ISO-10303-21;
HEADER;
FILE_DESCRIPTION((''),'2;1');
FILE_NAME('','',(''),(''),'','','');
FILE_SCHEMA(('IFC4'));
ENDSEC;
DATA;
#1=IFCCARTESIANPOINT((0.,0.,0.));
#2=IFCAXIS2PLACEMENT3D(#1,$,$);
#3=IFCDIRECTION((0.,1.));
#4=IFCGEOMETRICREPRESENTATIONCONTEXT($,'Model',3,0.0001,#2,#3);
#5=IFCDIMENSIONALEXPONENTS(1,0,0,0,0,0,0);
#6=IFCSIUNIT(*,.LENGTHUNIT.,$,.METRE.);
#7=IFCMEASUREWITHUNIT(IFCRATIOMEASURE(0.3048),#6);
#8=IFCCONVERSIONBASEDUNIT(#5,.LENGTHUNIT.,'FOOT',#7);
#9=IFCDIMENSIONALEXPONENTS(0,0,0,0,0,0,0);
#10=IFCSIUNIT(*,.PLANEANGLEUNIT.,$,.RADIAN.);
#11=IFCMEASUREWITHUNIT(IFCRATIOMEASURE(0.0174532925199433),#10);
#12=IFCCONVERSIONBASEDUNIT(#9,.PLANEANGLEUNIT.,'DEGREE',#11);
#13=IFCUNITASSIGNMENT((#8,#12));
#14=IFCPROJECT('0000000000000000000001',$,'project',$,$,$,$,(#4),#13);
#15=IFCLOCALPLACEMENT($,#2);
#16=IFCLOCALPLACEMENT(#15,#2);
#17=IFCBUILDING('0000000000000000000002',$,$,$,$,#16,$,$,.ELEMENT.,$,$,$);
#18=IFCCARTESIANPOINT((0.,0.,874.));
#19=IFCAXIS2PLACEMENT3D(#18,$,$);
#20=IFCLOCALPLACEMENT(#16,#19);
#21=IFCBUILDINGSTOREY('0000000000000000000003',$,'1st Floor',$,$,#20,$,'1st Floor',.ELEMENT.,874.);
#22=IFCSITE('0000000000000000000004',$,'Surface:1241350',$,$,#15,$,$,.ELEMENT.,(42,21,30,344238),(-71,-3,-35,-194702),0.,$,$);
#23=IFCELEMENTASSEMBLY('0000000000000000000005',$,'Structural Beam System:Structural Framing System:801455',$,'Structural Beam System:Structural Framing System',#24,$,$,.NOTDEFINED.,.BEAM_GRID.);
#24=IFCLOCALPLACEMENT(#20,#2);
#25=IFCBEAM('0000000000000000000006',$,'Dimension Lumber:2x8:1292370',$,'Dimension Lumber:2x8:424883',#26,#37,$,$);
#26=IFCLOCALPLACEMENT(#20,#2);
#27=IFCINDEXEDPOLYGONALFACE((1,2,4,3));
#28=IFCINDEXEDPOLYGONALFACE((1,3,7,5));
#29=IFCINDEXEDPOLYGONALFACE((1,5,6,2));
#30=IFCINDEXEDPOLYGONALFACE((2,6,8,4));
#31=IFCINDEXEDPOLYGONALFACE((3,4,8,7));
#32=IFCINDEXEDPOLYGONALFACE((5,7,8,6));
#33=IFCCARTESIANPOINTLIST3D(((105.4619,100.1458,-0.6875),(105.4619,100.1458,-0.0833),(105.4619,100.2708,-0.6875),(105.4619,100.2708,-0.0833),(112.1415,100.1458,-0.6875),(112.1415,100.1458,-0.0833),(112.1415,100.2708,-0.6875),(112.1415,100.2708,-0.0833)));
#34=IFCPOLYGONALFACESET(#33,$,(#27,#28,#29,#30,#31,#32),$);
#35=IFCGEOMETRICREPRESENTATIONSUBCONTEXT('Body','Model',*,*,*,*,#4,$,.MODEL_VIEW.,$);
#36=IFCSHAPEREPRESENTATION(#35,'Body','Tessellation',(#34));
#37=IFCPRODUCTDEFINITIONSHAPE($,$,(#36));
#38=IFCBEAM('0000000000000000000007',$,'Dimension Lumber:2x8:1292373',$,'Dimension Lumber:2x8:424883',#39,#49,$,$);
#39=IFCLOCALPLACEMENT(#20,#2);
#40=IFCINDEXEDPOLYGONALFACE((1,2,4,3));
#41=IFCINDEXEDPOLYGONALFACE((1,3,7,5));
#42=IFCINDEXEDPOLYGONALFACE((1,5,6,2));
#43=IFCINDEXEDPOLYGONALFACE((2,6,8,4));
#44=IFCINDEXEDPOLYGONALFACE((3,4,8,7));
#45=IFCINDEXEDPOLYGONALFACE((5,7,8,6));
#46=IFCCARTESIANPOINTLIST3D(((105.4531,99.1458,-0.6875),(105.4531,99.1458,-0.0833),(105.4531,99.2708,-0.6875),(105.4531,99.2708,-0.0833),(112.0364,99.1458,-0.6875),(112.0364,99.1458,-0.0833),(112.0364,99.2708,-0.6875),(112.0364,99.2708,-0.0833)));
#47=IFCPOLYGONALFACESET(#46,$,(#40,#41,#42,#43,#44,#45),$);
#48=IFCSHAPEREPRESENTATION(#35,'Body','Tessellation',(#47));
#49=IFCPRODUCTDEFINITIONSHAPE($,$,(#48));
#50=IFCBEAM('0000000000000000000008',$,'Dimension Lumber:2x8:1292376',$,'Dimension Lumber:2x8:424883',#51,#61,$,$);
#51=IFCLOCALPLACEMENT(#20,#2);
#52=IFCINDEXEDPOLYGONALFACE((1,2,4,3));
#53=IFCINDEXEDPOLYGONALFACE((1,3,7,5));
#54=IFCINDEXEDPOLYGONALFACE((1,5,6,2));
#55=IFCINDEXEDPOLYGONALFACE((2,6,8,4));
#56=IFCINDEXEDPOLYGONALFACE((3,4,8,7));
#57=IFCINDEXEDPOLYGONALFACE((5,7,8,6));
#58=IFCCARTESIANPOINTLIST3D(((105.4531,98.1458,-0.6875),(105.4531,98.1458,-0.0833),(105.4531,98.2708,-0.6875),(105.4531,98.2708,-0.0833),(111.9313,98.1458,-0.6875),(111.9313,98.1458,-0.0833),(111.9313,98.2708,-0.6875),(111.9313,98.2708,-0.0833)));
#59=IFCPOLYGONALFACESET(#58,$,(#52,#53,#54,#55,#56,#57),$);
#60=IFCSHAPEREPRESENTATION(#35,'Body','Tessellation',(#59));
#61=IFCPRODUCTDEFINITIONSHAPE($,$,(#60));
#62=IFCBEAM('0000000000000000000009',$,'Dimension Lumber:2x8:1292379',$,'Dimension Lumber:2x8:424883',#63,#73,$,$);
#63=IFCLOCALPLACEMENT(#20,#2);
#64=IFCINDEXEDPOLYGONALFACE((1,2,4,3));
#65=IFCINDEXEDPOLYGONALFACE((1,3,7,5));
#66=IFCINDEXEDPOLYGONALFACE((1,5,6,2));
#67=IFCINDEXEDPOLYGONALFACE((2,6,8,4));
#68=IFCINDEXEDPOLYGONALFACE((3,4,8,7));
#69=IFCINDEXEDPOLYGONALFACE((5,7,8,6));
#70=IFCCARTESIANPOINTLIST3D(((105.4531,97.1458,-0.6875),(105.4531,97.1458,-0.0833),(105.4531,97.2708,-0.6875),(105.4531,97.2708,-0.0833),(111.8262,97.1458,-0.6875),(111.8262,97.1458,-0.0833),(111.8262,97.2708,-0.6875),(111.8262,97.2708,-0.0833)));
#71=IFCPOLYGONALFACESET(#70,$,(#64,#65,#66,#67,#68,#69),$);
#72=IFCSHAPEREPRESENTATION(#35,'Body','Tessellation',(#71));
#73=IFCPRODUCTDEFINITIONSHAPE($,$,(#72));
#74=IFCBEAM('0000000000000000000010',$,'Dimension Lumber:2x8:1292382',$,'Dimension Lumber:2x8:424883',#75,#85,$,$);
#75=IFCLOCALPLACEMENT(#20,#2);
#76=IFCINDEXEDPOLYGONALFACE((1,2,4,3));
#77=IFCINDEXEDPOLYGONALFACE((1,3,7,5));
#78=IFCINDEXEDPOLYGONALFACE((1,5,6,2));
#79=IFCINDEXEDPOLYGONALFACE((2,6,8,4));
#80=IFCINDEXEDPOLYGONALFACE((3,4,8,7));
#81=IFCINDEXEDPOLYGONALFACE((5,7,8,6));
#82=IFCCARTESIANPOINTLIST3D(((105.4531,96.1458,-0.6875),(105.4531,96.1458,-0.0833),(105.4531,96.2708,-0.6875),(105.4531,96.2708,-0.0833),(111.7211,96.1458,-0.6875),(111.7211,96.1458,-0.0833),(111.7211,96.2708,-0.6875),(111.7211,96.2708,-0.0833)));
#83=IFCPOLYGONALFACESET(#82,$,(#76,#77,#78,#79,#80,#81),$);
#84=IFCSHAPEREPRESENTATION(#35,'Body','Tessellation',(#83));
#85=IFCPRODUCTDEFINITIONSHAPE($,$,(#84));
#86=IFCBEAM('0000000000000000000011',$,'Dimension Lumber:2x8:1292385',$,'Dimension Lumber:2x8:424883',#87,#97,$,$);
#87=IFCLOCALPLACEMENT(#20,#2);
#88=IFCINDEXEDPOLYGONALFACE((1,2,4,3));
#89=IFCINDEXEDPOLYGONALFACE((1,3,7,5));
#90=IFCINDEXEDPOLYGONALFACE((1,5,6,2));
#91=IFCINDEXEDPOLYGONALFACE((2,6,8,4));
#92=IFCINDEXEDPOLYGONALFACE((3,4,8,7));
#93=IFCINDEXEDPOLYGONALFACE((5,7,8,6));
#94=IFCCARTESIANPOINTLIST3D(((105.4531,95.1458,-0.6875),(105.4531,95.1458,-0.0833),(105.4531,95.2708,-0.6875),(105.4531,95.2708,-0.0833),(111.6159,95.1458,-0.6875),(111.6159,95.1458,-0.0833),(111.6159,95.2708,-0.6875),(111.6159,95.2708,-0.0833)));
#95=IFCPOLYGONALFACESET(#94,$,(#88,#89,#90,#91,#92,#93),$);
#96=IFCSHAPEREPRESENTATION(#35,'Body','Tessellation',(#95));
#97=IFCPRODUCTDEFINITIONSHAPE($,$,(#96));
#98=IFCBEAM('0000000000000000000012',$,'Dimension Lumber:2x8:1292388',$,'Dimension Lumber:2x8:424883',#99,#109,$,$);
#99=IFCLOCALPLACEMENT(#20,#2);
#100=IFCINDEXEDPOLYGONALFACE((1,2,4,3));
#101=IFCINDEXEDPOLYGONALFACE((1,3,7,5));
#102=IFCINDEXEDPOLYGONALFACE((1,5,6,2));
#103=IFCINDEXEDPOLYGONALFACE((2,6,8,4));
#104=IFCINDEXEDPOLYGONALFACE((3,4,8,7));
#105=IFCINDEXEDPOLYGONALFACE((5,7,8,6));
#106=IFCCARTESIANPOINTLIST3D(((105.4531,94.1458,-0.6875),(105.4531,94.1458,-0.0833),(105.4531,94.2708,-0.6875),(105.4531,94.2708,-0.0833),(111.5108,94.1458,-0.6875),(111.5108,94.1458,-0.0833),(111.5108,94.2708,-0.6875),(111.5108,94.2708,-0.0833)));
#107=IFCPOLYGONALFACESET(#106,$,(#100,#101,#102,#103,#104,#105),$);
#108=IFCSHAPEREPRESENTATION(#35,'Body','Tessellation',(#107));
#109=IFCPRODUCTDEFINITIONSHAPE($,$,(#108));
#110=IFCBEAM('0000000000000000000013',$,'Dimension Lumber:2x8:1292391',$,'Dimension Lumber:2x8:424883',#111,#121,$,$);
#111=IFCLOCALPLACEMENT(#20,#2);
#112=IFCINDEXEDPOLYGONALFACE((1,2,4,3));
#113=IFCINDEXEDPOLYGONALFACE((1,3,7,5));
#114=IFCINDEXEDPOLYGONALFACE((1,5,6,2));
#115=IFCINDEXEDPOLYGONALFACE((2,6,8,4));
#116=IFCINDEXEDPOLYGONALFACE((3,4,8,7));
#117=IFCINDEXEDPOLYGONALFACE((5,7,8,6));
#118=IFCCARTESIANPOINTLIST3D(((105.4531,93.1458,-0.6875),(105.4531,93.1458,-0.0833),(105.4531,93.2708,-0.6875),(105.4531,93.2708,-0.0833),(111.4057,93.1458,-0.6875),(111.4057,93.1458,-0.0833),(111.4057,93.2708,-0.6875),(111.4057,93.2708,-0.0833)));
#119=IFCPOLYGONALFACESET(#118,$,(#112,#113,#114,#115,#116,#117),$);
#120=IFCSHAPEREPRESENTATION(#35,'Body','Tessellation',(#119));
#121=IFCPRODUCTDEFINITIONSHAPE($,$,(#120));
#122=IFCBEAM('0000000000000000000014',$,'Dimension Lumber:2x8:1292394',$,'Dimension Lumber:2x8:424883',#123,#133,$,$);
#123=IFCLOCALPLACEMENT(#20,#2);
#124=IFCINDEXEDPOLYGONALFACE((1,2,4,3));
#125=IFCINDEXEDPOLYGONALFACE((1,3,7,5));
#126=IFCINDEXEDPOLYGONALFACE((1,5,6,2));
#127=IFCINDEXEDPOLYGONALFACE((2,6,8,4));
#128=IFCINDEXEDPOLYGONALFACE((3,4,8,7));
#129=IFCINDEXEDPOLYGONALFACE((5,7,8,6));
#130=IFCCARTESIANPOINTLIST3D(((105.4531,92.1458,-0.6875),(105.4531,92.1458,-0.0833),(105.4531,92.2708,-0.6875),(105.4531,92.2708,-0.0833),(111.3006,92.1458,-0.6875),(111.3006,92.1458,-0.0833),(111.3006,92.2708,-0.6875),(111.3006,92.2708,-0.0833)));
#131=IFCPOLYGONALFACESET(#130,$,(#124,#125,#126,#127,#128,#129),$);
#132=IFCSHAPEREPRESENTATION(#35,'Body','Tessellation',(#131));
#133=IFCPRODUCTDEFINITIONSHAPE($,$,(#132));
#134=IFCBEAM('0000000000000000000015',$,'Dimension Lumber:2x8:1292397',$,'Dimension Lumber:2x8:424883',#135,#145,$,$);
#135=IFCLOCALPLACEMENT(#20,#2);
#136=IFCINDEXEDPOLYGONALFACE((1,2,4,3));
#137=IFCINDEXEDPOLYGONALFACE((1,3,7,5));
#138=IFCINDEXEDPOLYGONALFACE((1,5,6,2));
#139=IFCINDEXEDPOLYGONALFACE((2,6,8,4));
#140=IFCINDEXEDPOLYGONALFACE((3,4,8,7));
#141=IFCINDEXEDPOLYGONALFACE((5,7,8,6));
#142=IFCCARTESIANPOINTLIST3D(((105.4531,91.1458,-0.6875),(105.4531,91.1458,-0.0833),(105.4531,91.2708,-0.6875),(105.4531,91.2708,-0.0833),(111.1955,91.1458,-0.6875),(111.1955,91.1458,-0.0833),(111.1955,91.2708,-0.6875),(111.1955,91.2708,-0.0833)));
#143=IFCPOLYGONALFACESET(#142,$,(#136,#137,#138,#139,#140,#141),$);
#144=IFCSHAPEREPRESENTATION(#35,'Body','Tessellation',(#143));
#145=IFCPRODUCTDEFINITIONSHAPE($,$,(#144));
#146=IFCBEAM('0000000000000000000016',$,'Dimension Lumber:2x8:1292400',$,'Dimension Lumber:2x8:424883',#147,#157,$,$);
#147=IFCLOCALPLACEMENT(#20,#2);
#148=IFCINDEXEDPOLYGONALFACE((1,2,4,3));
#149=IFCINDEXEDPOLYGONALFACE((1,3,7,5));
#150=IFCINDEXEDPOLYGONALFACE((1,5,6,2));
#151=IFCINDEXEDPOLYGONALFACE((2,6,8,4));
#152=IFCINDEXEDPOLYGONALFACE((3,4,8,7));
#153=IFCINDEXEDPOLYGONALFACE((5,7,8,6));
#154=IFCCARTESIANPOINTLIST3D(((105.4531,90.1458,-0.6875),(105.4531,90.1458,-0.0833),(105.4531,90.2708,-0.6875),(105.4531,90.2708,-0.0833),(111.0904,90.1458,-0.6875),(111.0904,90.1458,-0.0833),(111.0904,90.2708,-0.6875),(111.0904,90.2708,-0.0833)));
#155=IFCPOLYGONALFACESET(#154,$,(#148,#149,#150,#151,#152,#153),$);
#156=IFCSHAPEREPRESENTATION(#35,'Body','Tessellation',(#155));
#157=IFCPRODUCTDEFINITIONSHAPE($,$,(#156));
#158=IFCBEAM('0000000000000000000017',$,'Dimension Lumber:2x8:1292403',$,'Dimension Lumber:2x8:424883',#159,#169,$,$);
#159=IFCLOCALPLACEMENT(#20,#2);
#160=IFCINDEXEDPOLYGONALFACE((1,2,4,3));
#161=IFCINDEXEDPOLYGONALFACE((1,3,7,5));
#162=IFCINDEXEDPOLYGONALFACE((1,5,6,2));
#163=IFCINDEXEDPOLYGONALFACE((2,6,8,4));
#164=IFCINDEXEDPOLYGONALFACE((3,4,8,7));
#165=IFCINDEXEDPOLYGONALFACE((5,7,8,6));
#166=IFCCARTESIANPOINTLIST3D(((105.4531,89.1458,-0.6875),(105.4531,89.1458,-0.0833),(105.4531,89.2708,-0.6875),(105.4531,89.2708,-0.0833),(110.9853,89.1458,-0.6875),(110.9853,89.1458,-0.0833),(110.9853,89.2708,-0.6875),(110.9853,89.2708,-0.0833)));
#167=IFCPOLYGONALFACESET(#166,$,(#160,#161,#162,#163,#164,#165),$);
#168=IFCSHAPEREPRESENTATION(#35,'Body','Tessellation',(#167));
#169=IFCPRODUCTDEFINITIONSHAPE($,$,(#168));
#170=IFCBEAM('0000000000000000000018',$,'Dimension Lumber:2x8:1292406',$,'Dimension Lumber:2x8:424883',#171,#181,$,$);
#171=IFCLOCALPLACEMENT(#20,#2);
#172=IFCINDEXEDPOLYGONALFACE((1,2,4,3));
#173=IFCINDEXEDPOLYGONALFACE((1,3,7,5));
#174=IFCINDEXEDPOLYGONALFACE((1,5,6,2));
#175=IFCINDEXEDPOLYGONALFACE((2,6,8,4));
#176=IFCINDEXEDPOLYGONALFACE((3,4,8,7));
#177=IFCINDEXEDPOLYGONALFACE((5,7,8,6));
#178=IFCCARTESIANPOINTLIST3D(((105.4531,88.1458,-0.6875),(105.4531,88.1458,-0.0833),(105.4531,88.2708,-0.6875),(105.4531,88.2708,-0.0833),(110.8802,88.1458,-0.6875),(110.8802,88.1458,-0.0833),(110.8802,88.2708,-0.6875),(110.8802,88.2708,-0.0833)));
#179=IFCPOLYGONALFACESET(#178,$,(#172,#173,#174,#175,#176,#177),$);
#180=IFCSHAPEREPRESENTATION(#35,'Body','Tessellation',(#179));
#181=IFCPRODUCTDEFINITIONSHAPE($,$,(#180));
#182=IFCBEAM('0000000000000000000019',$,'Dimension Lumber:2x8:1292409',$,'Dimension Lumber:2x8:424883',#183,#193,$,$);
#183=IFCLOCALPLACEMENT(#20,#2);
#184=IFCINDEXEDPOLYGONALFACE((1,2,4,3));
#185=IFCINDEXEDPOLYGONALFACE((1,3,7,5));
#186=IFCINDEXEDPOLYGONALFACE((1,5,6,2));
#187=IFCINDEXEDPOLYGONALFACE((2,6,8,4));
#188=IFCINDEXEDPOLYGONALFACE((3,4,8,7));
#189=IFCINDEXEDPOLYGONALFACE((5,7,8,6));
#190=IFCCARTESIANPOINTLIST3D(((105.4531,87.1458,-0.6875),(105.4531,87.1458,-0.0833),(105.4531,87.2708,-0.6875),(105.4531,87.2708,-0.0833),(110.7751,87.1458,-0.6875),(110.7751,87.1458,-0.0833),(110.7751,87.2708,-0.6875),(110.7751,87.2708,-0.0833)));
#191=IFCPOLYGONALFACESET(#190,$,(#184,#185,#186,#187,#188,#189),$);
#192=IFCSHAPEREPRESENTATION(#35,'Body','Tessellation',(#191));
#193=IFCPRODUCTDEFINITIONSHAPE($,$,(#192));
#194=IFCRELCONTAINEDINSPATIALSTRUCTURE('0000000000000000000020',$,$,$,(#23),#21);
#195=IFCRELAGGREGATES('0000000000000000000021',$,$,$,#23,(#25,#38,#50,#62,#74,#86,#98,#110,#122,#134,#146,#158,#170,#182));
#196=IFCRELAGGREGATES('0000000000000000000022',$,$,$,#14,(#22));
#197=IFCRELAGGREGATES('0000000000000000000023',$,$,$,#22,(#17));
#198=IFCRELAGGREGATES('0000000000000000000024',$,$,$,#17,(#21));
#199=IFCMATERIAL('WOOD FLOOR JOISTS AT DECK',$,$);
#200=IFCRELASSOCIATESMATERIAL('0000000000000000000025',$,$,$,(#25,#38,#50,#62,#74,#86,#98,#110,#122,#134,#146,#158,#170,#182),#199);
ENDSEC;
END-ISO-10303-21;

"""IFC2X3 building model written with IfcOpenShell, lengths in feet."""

from ifc_helpers import new_model, entity, si_unit, converted_unit, direction, frame, origin, origin_2d_with_axis, place, context, subcontext, project, spatial, rectangle, extrude, material, element, aggregate, save


model = new_model("IFC2X3")

# Units and contexts
model_context = context("Model", 3, precision=0.0001, world=origin(), true_north=direction((0.0, 1.0)))
body_context = subcontext(model_context, "Body", "Model", "MODEL_VIEW")
ifc_project = project(units=[converted_unit("LENGTHUNIT", "FOOT", entity("IfcRatioMeasure", 0.3048), si_unit("LENGTHUNIT", "METRE"), dimensions=[1, 0, 0, 0, 0, 0, 0]), converted_unit("PLANEANGLEUNIT", "DEGREE", entity("IfcRatioMeasure", 0.0174532925199433), si_unit("PLANEANGLEUNIT", "RADIAN"), dimensions=[0, 0, 0, 0, 0, 0, 0])], contexts=[model_context])

# Site, building, storey
site_placement = place(None, origin())
site = spatial("IfcSite", under=ifc_project, at=site_placement, Name="Surface:1241350", CompositionType="ELEMENT", RefLatitude=(42, 21, 30, 344238), RefLongitude=(-71, -3, -35, -194702), RefElevation=0.0)
building_placement = place(site_placement, origin())
building = spatial("IfcBuilding", under=site, at=building_placement, CompositionType="ELEMENT")
storey_placement = place(building_placement, frame((0.0, 0.0, 874.0)))
storey = spatial("IfcBuildingStorey", under=building, at=storey_placement, Name="1st Floor", LongName="1st Floor", CompositionType="ELEMENT", Elevation=874.0)

# Element assembly, beams
assembly_placement = place(storey_placement, origin())
assembly = element("IfcElementAssembly", 1, at=assembly_placement, inside=storey, Name="Structural Beam System:Structural Framing System:801455", ObjectType="Structural Beam System:Structural Framing System", AssemblyPlace="NOTDEFINED", PredefinedType="BEAM_GRID")
ifc_material_1 = material(Name="WOOD FLOOR JOISTS AT DECK")
beam_1_placement = place(assembly_placement, frame((105.4619, 100.2083, 0.0)))
beam_1 = element("IfcBeam", 2, at=beam_1_placement, material=ifc_material_1, Name="Dimension Lumber:2x8:1292370", ObjectType="Dimension Lumber:2x8:424883", context=body_context, shape_type="SweptSolid", body=[
    extrude(rectangle(XDim=0.6042, YDim=0.125, at=origin_2d_with_axis()), frame((0.0, 0.0, -0.3854), z_axis=(1.0, 0.0, 0.0), x_axis=(0.0, 0.0, -1.0)), (0.0, 0.0, 1.0), 6.6796),
])
beam_2_placement = place(assembly_placement, frame((105.3906, 99.2083, 0.0)))
beam_2 = element("IfcBeam", 3, at=beam_2_placement, material=ifc_material_1, Name="Dimension Lumber:2x8:1292373", ObjectType="Dimension Lumber:2x8:424883", context=body_context, shape_type="SweptSolid", body=[
    extrude(rectangle(XDim=0.6042, YDim=0.125, at=origin_2d_with_axis()), frame((0.0625, 0.0, -0.3854), z_axis=(1.0, 0.0, 0.0), x_axis=(0.0, 0.0, -1.0)), (0.0, 0.0, 1.0), 6.5832),
])
beam_3_placement = place(assembly_placement, frame((105.3906, 98.2083, 0.0)))
beam_3 = element("IfcBeam", 4, at=beam_3_placement, material=ifc_material_1, Name="Dimension Lumber:2x8:1292376", ObjectType="Dimension Lumber:2x8:424883", context=body_context, shape_type="SweptSolid", body=[
    extrude(rectangle(XDim=0.6042, YDim=0.125, at=origin_2d_with_axis()), frame((0.0625, 0.0, -0.3854), z_axis=(1.0, 0.0, 0.0), x_axis=(0.0, 0.0, -1.0)), (0.0, 0.0, 1.0), 6.4781),
])
beam_4_placement = place(assembly_placement, frame((105.3906, 97.2083, 0.0)))
beam_4 = element("IfcBeam", 5, at=beam_4_placement, material=ifc_material_1, Name="Dimension Lumber:2x8:1292379", ObjectType="Dimension Lumber:2x8:424883", context=body_context, shape_type="SweptSolid", body=[
    extrude(rectangle(XDim=0.6042, YDim=0.125, at=origin_2d_with_axis()), frame((0.0625, 0.0, -0.3854), z_axis=(1.0, 0.0, 0.0), x_axis=(0.0, 0.0, -1.0)), (0.0, 0.0, 1.0), 6.373),
])
beam_5_placement = place(assembly_placement, frame((105.3906, 96.2083, 0.0)))
beam_5 = element("IfcBeam", 6, at=beam_5_placement, material=ifc_material_1, Name="Dimension Lumber:2x8:1292382", ObjectType="Dimension Lumber:2x8:424883", context=body_context, shape_type="SweptSolid", body=[
    extrude(rectangle(XDim=0.6042, YDim=0.125, at=origin_2d_with_axis()), frame((0.0625, 0.0, -0.3854), z_axis=(1.0, 0.0, 0.0), x_axis=(0.0, 0.0, -1.0)), (0.0, 0.0, 1.0), 6.2679),
])
beam_6_placement = place(assembly_placement, frame((105.3906, 95.2083, 0.0)))
beam_6 = element("IfcBeam", 7, at=beam_6_placement, material=ifc_material_1, Name="Dimension Lumber:2x8:1292385", ObjectType="Dimension Lumber:2x8:424883", context=body_context, shape_type="SweptSolid", body=[
    extrude(rectangle(XDim=0.6042, YDim=0.125, at=origin_2d_with_axis()), frame((0.0625, 0.0, -0.3854), z_axis=(1.0, 0.0, 0.0), x_axis=(0.0, 0.0, -1.0)), (0.0, 0.0, 1.0), 6.1628),
])
beam_7_placement = place(assembly_placement, frame((105.3906, 94.2083, 0.0)))
beam_7 = element("IfcBeam", 8, at=beam_7_placement, material=ifc_material_1, Name="Dimension Lumber:2x8:1292388", ObjectType="Dimension Lumber:2x8:424883", context=body_context, shape_type="SweptSolid", body=[
    extrude(rectangle(XDim=0.6042, YDim=0.125, at=origin_2d_with_axis()), frame((0.0625, 0.0, -0.3854), z_axis=(1.0, 0.0, 0.0), x_axis=(0.0, 0.0, -1.0)), (0.0, 0.0, 1.0), 6.0577),
])
beam_8_placement = place(assembly_placement, frame((105.3906, 93.2083, 0.0)))
beam_8 = element("IfcBeam", 9, at=beam_8_placement, material=ifc_material_1, Name="Dimension Lumber:2x8:1292391", ObjectType="Dimension Lumber:2x8:424883", context=body_context, shape_type="SweptSolid", body=[
    extrude(rectangle(XDim=0.6042, YDim=0.125, at=origin_2d_with_axis()), frame((0.0625, 0.0, -0.3854), z_axis=(1.0, 0.0, 0.0), x_axis=(0.0, 0.0, -1.0)), (0.0, 0.0, 1.0), 5.9526),
])
beam_9_placement = place(assembly_placement, frame((105.3906, 92.2083, 0.0)))
beam_9 = element("IfcBeam", 10, at=beam_9_placement, material=ifc_material_1, Name="Dimension Lumber:2x8:1292394", ObjectType="Dimension Lumber:2x8:424883", context=body_context, shape_type="SweptSolid", body=[
    extrude(rectangle(XDim=0.6042, YDim=0.125, at=origin_2d_with_axis()), frame((0.0625, 0.0, -0.3854), z_axis=(1.0, 0.0, 0.0), x_axis=(0.0, 0.0, -1.0)), (0.0, 0.0, 1.0), 5.8475),
])
beam_10_placement = place(assembly_placement, frame((105.3906, 91.2083, 0.0)))
beam_10 = element("IfcBeam", 11, at=beam_10_placement, material=ifc_material_1, Name="Dimension Lumber:2x8:1292397", ObjectType="Dimension Lumber:2x8:424883", context=body_context, shape_type="SweptSolid", body=[
    extrude(rectangle(XDim=0.6042, YDim=0.125, at=origin_2d_with_axis()), frame((0.0625, 0.0, -0.3854), z_axis=(1.0, 0.0, 0.0), x_axis=(0.0, 0.0, -1.0)), (0.0, 0.0, 1.0), 5.7424),
])
beam_11_placement = place(assembly_placement, frame((105.3906, 90.2083, 0.0)))
beam_11 = element("IfcBeam", 12, at=beam_11_placement, material=ifc_material_1, Name="Dimension Lumber:2x8:1292400", ObjectType="Dimension Lumber:2x8:424883", context=body_context, shape_type="SweptSolid", body=[
    extrude(rectangle(XDim=0.6042, YDim=0.125, at=origin_2d_with_axis()), frame((0.0625, 0.0, -0.3854), z_axis=(1.0, 0.0, 0.0), x_axis=(0.0, 0.0, -1.0)), (0.0, 0.0, 1.0), 5.6373),
])
beam_12_placement = place(assembly_placement, frame((105.3906, 89.2083, 0.0)))
beam_12 = element("IfcBeam", 13, at=beam_12_placement, material=ifc_material_1, Name="Dimension Lumber:2x8:1292403", ObjectType="Dimension Lumber:2x8:424883", context=body_context, shape_type="SweptSolid", body=[
    extrude(rectangle(XDim=0.6042, YDim=0.125, at=origin_2d_with_axis()), frame((0.0625, 0.0, -0.3854), z_axis=(1.0, 0.0, 0.0), x_axis=(0.0, 0.0, -1.0)), (0.0, 0.0, 1.0), 5.5322),
])
beam_13_placement = place(assembly_placement, frame((105.3906, 88.2083, 0.0)))
beam_13 = element("IfcBeam", 14, at=beam_13_placement, material=ifc_material_1, Name="Dimension Lumber:2x8:1292406", ObjectType="Dimension Lumber:2x8:424883", context=body_context, shape_type="SweptSolid", body=[
    extrude(rectangle(XDim=0.6042, YDim=0.125, at=origin_2d_with_axis()), frame((0.0625, 0.0, -0.3854), z_axis=(1.0, 0.0, 0.0), x_axis=(0.0, 0.0, -1.0)), (0.0, 0.0, 1.0), 5.4271),
])
beam_14_placement = place(assembly_placement, frame((105.3906, 87.2083, 0.0)))
beam_14 = element("IfcBeam", 15, at=beam_14_placement, material=ifc_material_1, Name="Dimension Lumber:2x8:1292409", ObjectType="Dimension Lumber:2x8:424883", context=body_context, shape_type="SweptSolid", body=[
    extrude(rectangle(XDim=0.6042, YDim=0.125, at=origin_2d_with_axis()), frame((0.0625, 0.0, -0.3854), z_axis=(1.0, 0.0, 0.0), x_axis=(0.0, 0.0, -1.0)), (0.0, 0.0, 1.0), 5.322),
])
aggregate(assembly, [beam_1, beam_2, beam_3, beam_4, beam_5, beam_6, beam_7, beam_8, beam_9, beam_10, beam_11, beam_12, beam_13, beam_14])

save(model, "model.ifc")
